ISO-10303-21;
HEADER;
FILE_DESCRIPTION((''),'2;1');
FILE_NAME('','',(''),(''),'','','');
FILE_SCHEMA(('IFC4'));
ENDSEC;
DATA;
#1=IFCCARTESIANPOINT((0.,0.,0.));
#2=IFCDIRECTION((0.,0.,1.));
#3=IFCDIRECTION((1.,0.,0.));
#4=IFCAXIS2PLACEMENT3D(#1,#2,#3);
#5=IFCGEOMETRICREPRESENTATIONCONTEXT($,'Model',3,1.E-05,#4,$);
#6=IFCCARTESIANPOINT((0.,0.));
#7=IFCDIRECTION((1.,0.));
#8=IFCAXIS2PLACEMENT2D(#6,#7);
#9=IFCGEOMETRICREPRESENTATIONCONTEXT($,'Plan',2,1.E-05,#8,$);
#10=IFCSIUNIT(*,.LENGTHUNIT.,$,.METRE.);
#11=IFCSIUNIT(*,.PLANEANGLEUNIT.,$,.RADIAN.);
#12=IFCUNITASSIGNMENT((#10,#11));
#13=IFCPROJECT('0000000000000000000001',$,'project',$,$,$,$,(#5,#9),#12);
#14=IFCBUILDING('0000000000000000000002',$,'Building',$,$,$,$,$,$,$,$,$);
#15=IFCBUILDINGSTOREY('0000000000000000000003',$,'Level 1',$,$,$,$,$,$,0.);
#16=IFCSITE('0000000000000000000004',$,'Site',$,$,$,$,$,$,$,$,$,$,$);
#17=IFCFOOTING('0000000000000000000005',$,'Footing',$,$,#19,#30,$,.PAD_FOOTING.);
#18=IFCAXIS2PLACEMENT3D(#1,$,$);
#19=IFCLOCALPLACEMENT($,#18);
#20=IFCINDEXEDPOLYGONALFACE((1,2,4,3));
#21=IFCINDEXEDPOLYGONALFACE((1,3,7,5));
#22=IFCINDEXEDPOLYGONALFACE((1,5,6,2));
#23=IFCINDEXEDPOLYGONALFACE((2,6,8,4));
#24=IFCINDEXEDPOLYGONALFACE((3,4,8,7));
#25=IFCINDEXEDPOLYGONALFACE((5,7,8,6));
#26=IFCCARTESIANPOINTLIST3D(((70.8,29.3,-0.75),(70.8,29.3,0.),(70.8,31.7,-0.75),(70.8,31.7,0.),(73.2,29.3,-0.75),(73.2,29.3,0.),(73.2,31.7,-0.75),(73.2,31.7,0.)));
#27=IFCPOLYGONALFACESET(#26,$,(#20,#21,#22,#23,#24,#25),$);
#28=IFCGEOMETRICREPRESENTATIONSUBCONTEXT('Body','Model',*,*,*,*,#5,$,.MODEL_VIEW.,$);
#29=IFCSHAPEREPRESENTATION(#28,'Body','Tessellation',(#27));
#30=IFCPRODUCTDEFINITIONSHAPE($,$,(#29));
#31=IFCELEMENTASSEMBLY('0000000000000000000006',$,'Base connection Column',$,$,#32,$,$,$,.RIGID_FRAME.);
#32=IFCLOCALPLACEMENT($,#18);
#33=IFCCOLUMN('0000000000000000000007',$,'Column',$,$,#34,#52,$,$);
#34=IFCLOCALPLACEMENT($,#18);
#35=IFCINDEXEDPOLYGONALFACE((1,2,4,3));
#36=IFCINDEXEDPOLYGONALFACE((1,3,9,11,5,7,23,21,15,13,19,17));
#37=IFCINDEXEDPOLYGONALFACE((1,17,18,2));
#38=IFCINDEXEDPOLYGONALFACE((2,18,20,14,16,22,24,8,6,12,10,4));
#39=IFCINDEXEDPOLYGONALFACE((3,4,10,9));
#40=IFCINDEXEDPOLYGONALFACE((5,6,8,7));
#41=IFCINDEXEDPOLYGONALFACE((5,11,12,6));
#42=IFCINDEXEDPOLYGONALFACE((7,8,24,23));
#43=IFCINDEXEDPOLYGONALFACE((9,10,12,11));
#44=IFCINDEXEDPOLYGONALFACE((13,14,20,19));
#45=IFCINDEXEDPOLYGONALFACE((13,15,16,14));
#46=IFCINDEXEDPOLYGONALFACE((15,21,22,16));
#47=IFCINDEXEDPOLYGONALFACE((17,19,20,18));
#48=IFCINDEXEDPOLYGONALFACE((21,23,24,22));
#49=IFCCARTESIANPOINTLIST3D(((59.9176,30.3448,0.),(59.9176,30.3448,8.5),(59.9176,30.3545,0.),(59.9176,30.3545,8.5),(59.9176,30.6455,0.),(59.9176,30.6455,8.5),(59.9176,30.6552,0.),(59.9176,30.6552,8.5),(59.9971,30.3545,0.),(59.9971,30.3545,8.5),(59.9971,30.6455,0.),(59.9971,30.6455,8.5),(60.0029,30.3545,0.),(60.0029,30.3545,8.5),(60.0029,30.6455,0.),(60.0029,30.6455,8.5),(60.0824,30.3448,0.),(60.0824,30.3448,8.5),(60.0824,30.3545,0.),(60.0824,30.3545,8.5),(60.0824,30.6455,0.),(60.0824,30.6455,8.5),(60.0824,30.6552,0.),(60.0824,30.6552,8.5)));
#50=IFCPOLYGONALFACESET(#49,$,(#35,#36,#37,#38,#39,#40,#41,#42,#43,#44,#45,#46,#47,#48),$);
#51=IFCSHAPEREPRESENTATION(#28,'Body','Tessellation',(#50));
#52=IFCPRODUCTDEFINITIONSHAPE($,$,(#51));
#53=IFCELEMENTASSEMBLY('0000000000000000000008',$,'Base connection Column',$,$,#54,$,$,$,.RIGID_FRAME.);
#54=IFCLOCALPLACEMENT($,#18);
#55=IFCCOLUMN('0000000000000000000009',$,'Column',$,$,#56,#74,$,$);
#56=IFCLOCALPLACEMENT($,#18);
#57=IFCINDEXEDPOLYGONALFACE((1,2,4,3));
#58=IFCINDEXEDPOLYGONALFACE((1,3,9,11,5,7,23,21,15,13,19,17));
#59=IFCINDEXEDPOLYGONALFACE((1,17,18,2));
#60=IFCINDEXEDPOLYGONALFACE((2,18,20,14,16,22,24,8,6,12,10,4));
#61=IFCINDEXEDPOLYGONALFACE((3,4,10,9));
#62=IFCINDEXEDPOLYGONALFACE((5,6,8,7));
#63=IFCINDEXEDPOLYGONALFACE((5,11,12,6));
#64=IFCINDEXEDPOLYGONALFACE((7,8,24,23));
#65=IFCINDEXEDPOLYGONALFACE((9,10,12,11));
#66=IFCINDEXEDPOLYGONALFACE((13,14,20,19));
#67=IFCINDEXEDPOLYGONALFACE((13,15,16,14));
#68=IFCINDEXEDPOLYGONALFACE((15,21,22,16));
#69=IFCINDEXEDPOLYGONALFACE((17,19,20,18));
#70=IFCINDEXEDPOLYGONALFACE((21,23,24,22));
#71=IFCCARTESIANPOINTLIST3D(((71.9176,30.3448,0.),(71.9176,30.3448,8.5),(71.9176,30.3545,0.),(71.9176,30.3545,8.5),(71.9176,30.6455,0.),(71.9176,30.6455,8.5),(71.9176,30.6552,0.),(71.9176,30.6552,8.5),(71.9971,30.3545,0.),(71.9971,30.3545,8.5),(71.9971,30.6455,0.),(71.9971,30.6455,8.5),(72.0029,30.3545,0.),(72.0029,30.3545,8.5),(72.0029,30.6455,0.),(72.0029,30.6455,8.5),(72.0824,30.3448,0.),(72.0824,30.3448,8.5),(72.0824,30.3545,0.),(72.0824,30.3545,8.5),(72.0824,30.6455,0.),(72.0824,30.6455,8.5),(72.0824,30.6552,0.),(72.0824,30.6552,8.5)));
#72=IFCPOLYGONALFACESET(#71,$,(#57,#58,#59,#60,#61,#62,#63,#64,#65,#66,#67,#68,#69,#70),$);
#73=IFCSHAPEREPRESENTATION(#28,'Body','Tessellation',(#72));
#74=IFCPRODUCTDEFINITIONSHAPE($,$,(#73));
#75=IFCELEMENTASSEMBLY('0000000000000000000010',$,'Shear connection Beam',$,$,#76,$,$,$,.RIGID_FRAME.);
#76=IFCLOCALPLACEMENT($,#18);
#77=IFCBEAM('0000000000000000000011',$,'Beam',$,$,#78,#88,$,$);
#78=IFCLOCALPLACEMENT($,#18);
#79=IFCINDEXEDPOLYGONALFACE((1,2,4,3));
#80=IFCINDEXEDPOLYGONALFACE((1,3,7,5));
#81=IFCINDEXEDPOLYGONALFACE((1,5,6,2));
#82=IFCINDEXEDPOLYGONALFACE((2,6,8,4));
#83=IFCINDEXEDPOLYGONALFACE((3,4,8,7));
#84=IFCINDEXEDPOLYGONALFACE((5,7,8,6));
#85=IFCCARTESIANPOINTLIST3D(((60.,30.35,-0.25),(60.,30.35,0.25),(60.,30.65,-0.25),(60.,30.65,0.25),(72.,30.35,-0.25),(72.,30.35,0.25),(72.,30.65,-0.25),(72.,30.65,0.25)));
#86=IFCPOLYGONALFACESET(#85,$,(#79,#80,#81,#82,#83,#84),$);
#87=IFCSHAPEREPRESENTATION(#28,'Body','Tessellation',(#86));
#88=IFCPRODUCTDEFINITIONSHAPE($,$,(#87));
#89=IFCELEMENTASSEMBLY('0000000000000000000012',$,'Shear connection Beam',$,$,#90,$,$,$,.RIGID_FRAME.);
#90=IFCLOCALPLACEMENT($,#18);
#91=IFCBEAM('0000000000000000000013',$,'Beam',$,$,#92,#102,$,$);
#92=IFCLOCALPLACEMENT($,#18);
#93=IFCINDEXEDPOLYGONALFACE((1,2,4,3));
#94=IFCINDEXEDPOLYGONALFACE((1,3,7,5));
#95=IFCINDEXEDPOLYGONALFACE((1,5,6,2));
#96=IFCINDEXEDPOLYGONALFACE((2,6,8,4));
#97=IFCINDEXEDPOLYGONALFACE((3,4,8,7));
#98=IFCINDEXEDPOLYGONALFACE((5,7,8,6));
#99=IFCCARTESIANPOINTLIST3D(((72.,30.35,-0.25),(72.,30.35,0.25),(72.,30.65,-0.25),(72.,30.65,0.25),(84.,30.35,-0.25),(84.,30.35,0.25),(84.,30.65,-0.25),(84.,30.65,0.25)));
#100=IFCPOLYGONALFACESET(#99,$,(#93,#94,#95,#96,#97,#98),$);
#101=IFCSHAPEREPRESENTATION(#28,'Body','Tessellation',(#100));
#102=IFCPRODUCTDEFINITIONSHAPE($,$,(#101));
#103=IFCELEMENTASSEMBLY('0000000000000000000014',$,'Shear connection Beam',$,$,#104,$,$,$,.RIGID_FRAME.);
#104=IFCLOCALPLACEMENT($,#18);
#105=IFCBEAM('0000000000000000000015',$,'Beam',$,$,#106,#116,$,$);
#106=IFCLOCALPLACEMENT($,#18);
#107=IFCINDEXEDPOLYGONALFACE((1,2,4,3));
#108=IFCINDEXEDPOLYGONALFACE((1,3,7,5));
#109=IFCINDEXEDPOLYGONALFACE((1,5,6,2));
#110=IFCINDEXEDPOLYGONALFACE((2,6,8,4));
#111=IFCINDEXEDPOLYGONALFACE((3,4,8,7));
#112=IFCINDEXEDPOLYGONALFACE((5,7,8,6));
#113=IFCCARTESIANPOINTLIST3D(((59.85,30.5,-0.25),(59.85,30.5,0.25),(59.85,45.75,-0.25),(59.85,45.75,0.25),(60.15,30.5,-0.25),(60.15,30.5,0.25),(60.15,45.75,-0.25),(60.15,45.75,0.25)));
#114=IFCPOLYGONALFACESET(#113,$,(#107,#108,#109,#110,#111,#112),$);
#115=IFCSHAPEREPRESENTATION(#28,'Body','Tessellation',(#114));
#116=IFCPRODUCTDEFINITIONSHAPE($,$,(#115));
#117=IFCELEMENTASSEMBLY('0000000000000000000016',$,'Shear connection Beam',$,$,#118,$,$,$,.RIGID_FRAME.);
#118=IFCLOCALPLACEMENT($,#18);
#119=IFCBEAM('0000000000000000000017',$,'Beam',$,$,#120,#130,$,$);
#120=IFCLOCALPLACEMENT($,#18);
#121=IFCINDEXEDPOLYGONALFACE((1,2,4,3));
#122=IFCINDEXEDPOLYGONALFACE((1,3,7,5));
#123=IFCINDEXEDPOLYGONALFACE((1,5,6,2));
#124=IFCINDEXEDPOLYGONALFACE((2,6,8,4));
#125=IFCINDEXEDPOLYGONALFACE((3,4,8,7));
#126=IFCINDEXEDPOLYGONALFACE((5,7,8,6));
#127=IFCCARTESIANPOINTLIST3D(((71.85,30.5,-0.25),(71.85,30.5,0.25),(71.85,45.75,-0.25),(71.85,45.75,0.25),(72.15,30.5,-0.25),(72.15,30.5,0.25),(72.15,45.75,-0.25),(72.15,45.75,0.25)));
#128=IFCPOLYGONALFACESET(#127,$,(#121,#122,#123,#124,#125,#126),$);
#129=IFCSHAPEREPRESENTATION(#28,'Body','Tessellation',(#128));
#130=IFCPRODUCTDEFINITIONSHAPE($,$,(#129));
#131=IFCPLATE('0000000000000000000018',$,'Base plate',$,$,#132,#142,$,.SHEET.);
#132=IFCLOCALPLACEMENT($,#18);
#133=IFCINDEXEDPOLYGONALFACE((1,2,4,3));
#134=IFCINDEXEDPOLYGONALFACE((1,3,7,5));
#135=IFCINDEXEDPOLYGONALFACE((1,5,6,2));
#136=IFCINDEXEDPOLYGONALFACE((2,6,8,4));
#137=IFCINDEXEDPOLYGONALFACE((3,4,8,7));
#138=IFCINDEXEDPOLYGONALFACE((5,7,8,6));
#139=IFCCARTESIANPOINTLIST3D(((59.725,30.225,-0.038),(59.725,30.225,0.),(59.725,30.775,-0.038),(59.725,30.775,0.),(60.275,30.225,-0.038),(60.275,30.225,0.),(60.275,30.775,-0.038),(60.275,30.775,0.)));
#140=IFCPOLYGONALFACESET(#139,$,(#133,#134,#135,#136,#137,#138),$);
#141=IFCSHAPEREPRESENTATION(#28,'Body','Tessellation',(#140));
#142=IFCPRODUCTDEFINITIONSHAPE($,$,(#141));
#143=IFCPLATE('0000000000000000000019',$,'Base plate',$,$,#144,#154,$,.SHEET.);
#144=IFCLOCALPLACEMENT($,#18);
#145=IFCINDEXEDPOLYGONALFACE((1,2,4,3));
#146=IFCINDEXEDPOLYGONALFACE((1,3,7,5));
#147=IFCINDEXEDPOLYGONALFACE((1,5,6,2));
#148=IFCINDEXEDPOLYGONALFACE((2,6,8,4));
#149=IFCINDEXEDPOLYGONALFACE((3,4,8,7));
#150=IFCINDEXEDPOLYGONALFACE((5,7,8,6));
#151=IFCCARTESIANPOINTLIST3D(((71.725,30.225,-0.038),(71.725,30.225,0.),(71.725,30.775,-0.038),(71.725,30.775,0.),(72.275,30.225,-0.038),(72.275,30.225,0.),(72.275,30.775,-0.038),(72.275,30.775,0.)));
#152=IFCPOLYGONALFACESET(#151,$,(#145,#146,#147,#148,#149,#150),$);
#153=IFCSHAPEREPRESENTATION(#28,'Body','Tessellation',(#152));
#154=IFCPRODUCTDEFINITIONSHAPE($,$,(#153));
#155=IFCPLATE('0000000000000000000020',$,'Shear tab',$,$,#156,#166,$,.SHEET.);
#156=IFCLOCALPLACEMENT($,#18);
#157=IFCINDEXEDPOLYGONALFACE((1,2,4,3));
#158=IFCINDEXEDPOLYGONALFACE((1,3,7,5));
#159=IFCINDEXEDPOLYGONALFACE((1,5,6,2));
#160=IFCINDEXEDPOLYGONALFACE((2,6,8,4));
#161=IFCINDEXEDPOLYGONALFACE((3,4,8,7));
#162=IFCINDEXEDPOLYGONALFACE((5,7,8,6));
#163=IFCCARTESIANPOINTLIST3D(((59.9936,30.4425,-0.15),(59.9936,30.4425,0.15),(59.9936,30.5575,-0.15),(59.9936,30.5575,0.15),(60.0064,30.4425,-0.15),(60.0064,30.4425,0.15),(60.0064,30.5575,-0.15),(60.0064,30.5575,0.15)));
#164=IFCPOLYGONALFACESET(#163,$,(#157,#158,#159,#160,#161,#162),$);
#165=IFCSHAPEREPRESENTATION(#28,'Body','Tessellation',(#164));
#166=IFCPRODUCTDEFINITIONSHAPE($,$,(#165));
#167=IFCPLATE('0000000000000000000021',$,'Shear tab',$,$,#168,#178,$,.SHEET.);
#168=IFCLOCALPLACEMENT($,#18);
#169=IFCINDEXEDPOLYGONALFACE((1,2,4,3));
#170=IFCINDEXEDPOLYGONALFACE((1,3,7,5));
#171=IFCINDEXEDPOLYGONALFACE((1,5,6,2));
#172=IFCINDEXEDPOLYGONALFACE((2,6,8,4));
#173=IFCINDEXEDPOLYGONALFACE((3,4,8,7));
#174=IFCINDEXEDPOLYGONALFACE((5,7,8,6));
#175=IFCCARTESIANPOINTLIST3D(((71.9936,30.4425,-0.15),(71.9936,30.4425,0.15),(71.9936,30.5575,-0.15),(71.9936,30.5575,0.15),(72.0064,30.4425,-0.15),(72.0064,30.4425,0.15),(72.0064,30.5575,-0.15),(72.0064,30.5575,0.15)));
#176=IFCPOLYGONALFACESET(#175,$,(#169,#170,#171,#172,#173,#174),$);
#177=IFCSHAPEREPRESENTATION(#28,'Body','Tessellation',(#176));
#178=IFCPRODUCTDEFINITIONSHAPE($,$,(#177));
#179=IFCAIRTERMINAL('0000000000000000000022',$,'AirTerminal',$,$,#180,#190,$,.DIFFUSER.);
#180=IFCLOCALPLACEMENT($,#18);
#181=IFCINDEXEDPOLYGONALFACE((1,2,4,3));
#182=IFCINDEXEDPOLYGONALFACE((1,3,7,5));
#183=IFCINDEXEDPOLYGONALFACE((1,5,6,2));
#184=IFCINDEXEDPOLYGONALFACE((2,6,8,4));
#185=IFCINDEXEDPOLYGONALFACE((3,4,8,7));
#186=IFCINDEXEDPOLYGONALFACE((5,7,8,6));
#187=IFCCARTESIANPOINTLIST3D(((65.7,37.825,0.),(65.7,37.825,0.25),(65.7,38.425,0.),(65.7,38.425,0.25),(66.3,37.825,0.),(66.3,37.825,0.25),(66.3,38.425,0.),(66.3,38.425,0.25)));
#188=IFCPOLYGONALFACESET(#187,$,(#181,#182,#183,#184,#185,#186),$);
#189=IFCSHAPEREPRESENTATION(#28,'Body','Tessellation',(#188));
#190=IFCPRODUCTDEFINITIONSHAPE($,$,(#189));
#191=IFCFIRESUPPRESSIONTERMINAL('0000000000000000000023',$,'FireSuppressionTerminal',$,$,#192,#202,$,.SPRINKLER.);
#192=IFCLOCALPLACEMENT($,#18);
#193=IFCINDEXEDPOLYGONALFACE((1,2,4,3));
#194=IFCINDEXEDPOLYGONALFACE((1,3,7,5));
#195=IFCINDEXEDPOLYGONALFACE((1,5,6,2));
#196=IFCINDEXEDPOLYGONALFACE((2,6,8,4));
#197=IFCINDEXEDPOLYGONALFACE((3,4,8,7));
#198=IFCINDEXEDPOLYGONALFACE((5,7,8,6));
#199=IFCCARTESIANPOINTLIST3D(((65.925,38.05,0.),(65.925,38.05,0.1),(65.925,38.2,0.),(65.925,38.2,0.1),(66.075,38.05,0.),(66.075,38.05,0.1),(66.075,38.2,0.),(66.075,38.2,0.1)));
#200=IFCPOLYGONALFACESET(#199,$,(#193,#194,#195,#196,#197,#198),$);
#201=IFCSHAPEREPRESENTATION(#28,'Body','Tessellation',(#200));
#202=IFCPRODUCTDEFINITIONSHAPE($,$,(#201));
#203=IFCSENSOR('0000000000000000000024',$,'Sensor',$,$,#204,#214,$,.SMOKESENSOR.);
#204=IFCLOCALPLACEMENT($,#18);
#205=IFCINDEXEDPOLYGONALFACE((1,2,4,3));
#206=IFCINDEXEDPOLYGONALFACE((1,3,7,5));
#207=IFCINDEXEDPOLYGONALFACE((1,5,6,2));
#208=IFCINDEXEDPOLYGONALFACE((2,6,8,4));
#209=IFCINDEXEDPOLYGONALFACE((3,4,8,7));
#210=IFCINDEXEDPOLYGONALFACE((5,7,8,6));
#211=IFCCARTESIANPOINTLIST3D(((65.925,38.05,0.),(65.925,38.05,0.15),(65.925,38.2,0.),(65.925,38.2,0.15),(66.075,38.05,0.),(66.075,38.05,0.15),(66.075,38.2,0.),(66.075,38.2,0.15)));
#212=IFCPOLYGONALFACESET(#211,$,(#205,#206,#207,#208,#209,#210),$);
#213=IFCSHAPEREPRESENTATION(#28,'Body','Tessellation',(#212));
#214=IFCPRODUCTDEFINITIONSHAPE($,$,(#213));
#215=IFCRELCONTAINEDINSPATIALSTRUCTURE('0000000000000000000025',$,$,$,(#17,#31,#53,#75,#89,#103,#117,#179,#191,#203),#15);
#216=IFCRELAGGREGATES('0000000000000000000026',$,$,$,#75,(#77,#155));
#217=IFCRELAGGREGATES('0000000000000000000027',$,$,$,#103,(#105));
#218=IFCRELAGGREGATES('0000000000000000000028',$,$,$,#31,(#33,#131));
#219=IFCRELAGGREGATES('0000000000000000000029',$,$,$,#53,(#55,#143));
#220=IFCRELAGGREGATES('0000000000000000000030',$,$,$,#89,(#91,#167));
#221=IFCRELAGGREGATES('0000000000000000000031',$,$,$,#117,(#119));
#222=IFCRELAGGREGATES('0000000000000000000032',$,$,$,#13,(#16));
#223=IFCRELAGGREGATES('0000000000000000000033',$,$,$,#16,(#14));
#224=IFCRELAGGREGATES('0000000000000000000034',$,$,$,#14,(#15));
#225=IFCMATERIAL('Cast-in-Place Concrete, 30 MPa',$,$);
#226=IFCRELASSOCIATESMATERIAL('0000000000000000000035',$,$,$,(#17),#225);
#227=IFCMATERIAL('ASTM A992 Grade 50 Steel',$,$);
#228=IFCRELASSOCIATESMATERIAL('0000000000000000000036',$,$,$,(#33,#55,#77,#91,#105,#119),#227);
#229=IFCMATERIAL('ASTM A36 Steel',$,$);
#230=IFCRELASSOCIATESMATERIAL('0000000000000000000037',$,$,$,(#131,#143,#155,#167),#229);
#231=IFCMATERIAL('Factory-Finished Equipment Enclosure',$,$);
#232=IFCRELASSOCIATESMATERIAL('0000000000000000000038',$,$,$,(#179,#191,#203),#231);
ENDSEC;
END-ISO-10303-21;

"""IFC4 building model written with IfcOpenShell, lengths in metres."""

from ifc_helpers import new_model, si_unit, frame, origin_with_axes, origin_2d_with_axis, place, context, subcontext, project, spatial, rectangle, i_section, extrude, material, element, aggregate, save


model = new_model("IFC4")

# Units and contexts
model_context = context("Model", 3, precision=1e-05, world=origin_with_axes())
plan_context = context("Plan", 2, precision=1e-05, world=origin_2d_with_axis())
body_context = subcontext(model_context, "Body", "Model", "MODEL_VIEW")
ifc_project = project(units=[si_unit("LENGTHUNIT", "METRE"), si_unit("PLANEANGLEUNIT", "RADIAN")], contexts=[model_context, plan_context])

# Site, building, storey
site = spatial("IfcSite", under=ifc_project, Name="Site")
building = spatial("IfcBuilding", under=site, Name="Building")
storey = spatial("IfcBuildingStorey", under=building, Name="Level 1", Elevation=0.0)

# Footing
ifc_material_1 = material(Name="Cast-in-Place Concrete, 30 MPa")
footing_placement = place(None, frame((72.0, 30.5, -0.75), z_axis=(0.0, 0.0, 1.0), x_axis=(1.0, 0.0, 0.0)))
element("IfcFooting", 1, at=footing_placement, inside=storey, material=ifc_material_1, Name="Footing", PredefinedType="PAD_FOOTING", context=body_context, shape_type="SweptSolid", body=[
    extrude(rectangle(XDim=2.4, YDim=2.4, at=origin_2d_with_axis()), origin_with_axes(), (0.0, 0.0, 1.0), 0.75),
])

# Element assemblies, columns
assembly_1 = element("IfcElementAssembly", 2, inside=storey, Name="Base connection Column", PredefinedType="RIGID_FRAME")
ifc_material_2 = material(Name="ASTM A992 Grade 50 Steel")
column_1_placement = place(None, frame((60.0, 30.5, 0.0), z_axis=(0.0, 0.0, 1.0), x_axis=(1.0, 0.0, 0.0)))
column_1 = element("IfcColumn", 3, at=column_1_placement, material=ifc_material_2, Name="Column", context=body_context, shape_type="SweptSolid", body=[
    extrude(i_section(OverallWidth=0.1648, OverallDepth=0.3104, WebThickness=0.0058, FlangeThickness=0.0097, at=origin_2d_with_axis()), origin_with_axes(), (0.0, 0.0, 1.0), 8.5),
])
assembly_2 = element("IfcElementAssembly", 4, inside=storey, Name="Base connection Column", PredefinedType="RIGID_FRAME")
column_2_placement = place(None, frame((72.0, 30.5, 0.0), z_axis=(0.0, 0.0, 1.0), x_axis=(1.0, 0.0, 0.0)))
column_2 = element("IfcColumn", 5, at=column_2_placement, material=ifc_material_2, Name="Column", context=body_context, shape_type="SweptSolid", body=[
    extrude(i_section(OverallWidth=0.1648, OverallDepth=0.3104, WebThickness=0.0058, FlangeThickness=0.0097, at=origin_2d_with_axis()), origin_with_axes(), (0.0, 0.0, 1.0), 8.5),
])

# Element assemblies, beams
assembly_3 = element("IfcElementAssembly", 6, inside=storey, Name="Shear connection Beam", PredefinedType="RIGID_FRAME")
beam_1_placement = place(None, frame((60.0, 30.5, 0.0), z_axis=(1.0, 0.0, 0.0), x_axis=(0.0, 1.0, 0.0)))
beam_1 = element("IfcBeam", 7, at=beam_1_placement, material=ifc_material_2, Name="Beam", context=body_context, shape_type="SweptSolid", body=[
    extrude(rectangle(XDim=0.3, YDim=0.5, at=origin_2d_with_axis()), origin_with_axes(), (0.0, 0.0, 1.0), 12.0),
])
assembly_4 = element("IfcElementAssembly", 8, inside=storey, Name="Shear connection Beam", PredefinedType="RIGID_FRAME")
beam_2_placement = place(None, frame((72.0, 30.5, 0.0), z_axis=(1.0, 0.0, 0.0), x_axis=(0.0, 1.0, 0.0)))
beam_2 = element("IfcBeam", 9, at=beam_2_placement, material=ifc_material_2, Name="Beam", context=body_context, shape_type="SweptSolid", body=[
    extrude(rectangle(XDim=0.3, YDim=0.5, at=origin_2d_with_axis()), origin_with_axes(), (0.0, 0.0, 1.0), 12.0),
])
assembly_5 = element("IfcElementAssembly", 10, inside=storey, Name="Shear connection Beam", PredefinedType="RIGID_FRAME")
beam_3_placement = place(None, frame((60.0, 30.5, 0.0), z_axis=(0.0, 1.0, 0.0), x_axis=(-1.0, 0.0, 0.0)))
beam_3 = element("IfcBeam", 11, at=beam_3_placement, material=ifc_material_2, Name="Beam", context=body_context, shape_type="SweptSolid", body=[
    extrude(rectangle(XDim=0.3, YDim=0.5, at=origin_2d_with_axis()), origin_with_axes(), (0.0, 0.0, 1.0), 15.25),
])
assembly_6 = element("IfcElementAssembly", 12, inside=storey, Name="Shear connection Beam", PredefinedType="RIGID_FRAME")
beam_4_placement = place(None, frame((72.0, 30.5, 0.0), z_axis=(0.0, 1.0, 0.0), x_axis=(-1.0, 0.0, 0.0)))
beam_4 = element("IfcBeam", 13, at=beam_4_placement, material=ifc_material_2, Name="Beam", context=body_context, shape_type="SweptSolid", body=[
    extrude(rectangle(XDim=0.3, YDim=0.5, at=origin_2d_with_axis()), origin_with_axes(), (0.0, 0.0, 1.0), 15.25),
])

# Plates
ifc_material_3 = material(Name="ASTM A36 Steel")
plate_1_placement = place(None, frame((60.0, 30.5, -0.038), z_axis=(0.0, 0.0, 1.0), x_axis=(1.0, 0.0, 0.0)))
plate_1 = element("IfcPlate", 14, at=plate_1_placement, material=ifc_material_3, Name="Base plate", PredefinedType="SHEET", context=body_context, shape_type="SweptSolid", body=[
    extrude(rectangle(XDim=0.55, YDim=0.55, at=origin_2d_with_axis()), origin_with_axes(), (0.0, 0.0, 1.0), 0.038),
])
plate_2_placement = place(None, frame((72.0, 30.5, -0.038), z_axis=(0.0, 0.0, 1.0), x_axis=(1.0, 0.0, 0.0)))
plate_2 = element("IfcPlate", 15, at=plate_2_placement, material=ifc_material_3, Name="Base plate", PredefinedType="SHEET", context=body_context, shape_type="SweptSolid", body=[
    extrude(rectangle(XDim=0.55, YDim=0.55, at=origin_2d_with_axis()), origin_with_axes(), (0.0, 0.0, 1.0), 0.038),
])
plate_3_placement = place(None, frame((60.0, 30.5, -0.15), z_axis=(0.0, 0.0, 1.0), x_axis=(1.0, 0.0, 0.0)))
plate_3 = element("IfcPlate", 16, at=plate_3_placement, material=ifc_material_3, Name="Shear tab", PredefinedType="SHEET", context=body_context, shape_type="SweptSolid", body=[
    extrude(rectangle(XDim=0.0127, YDim=0.115, at=origin_2d_with_axis()), origin_with_axes(), (0.0, 0.0, 1.0), 0.3),
])
aggregate(assembly_3, [beam_1, plate_3])
plate_4_placement = place(None, frame((72.0, 30.5, -0.15), z_axis=(0.0, 0.0, 1.0), x_axis=(1.0, 0.0, 0.0)))
plate_4 = element("IfcPlate", 17, at=plate_4_placement, material=ifc_material_3, Name="Shear tab", PredefinedType="SHEET", context=body_context, shape_type="SweptSolid", body=[
    extrude(rectangle(XDim=0.0127, YDim=0.115, at=origin_2d_with_axis()), origin_with_axes(), (0.0, 0.0, 1.0), 0.3),
])
aggregate(assembly_5, [beam_3])

# Air terminal
ifc_material_4 = material(Name="Factory-Finished Equipment Enclosure")
air_terminal_placement = place(None, frame((66.0, 38.125, 0.0), z_axis=(0.0, 0.0, 1.0), x_axis=(1.0, 0.0, 0.0)))
element("IfcAirTerminal", 18, at=air_terminal_placement, inside=storey, material=ifc_material_4, Name="AirTerminal", PredefinedType="DIFFUSER", context=body_context, shape_type="SweptSolid", body=[
    extrude(rectangle(XDim=0.6, YDim=0.6, at=origin_2d_with_axis()), origin_with_axes(), (0.0, 0.0, 1.0), 0.25),
])

# Fire suppression terminal
fire_suppression_terminal_placement = place(None, frame((66.0, 38.125, 0.0), z_axis=(0.0, 0.0, 1.0), x_axis=(1.0, 0.0, 0.0)))
element("IfcFireSuppressionTerminal", 19, at=fire_suppression_terminal_placement, inside=storey, material=ifc_material_4, Name="FireSuppressionTerminal", PredefinedType="SPRINKLER", context=body_context, shape_type="SweptSolid", body=[
    extrude(rectangle(XDim=0.15, YDim=0.15, at=origin_2d_with_axis()), origin_with_axes(), (0.0, 0.0, 1.0), 0.1),
])

# Sensor
sensor_placement = place(None, frame((66.0, 38.125, 0.0), z_axis=(0.0, 0.0, 1.0), x_axis=(1.0, 0.0, 0.0)))
element("IfcSensor", 20, at=sensor_placement, inside=storey, material=ifc_material_4, Name="Sensor", PredefinedType="SMOKESENSOR", context=body_context, shape_type="SweptSolid", body=[
    extrude(rectangle(XDim=0.15, YDim=0.15, at=origin_2d_with_axis()), origin_with_axes(), (0.0, 0.0, 1.0), 0.15),
])

aggregate(assembly_1, [column_1, plate_1])

aggregate(assembly_2, [column_2, plate_2])

aggregate(assembly_4, [beam_2, plate_4])
aggregate(assembly_6, [beam_4])

save(model, "model.ifc")
